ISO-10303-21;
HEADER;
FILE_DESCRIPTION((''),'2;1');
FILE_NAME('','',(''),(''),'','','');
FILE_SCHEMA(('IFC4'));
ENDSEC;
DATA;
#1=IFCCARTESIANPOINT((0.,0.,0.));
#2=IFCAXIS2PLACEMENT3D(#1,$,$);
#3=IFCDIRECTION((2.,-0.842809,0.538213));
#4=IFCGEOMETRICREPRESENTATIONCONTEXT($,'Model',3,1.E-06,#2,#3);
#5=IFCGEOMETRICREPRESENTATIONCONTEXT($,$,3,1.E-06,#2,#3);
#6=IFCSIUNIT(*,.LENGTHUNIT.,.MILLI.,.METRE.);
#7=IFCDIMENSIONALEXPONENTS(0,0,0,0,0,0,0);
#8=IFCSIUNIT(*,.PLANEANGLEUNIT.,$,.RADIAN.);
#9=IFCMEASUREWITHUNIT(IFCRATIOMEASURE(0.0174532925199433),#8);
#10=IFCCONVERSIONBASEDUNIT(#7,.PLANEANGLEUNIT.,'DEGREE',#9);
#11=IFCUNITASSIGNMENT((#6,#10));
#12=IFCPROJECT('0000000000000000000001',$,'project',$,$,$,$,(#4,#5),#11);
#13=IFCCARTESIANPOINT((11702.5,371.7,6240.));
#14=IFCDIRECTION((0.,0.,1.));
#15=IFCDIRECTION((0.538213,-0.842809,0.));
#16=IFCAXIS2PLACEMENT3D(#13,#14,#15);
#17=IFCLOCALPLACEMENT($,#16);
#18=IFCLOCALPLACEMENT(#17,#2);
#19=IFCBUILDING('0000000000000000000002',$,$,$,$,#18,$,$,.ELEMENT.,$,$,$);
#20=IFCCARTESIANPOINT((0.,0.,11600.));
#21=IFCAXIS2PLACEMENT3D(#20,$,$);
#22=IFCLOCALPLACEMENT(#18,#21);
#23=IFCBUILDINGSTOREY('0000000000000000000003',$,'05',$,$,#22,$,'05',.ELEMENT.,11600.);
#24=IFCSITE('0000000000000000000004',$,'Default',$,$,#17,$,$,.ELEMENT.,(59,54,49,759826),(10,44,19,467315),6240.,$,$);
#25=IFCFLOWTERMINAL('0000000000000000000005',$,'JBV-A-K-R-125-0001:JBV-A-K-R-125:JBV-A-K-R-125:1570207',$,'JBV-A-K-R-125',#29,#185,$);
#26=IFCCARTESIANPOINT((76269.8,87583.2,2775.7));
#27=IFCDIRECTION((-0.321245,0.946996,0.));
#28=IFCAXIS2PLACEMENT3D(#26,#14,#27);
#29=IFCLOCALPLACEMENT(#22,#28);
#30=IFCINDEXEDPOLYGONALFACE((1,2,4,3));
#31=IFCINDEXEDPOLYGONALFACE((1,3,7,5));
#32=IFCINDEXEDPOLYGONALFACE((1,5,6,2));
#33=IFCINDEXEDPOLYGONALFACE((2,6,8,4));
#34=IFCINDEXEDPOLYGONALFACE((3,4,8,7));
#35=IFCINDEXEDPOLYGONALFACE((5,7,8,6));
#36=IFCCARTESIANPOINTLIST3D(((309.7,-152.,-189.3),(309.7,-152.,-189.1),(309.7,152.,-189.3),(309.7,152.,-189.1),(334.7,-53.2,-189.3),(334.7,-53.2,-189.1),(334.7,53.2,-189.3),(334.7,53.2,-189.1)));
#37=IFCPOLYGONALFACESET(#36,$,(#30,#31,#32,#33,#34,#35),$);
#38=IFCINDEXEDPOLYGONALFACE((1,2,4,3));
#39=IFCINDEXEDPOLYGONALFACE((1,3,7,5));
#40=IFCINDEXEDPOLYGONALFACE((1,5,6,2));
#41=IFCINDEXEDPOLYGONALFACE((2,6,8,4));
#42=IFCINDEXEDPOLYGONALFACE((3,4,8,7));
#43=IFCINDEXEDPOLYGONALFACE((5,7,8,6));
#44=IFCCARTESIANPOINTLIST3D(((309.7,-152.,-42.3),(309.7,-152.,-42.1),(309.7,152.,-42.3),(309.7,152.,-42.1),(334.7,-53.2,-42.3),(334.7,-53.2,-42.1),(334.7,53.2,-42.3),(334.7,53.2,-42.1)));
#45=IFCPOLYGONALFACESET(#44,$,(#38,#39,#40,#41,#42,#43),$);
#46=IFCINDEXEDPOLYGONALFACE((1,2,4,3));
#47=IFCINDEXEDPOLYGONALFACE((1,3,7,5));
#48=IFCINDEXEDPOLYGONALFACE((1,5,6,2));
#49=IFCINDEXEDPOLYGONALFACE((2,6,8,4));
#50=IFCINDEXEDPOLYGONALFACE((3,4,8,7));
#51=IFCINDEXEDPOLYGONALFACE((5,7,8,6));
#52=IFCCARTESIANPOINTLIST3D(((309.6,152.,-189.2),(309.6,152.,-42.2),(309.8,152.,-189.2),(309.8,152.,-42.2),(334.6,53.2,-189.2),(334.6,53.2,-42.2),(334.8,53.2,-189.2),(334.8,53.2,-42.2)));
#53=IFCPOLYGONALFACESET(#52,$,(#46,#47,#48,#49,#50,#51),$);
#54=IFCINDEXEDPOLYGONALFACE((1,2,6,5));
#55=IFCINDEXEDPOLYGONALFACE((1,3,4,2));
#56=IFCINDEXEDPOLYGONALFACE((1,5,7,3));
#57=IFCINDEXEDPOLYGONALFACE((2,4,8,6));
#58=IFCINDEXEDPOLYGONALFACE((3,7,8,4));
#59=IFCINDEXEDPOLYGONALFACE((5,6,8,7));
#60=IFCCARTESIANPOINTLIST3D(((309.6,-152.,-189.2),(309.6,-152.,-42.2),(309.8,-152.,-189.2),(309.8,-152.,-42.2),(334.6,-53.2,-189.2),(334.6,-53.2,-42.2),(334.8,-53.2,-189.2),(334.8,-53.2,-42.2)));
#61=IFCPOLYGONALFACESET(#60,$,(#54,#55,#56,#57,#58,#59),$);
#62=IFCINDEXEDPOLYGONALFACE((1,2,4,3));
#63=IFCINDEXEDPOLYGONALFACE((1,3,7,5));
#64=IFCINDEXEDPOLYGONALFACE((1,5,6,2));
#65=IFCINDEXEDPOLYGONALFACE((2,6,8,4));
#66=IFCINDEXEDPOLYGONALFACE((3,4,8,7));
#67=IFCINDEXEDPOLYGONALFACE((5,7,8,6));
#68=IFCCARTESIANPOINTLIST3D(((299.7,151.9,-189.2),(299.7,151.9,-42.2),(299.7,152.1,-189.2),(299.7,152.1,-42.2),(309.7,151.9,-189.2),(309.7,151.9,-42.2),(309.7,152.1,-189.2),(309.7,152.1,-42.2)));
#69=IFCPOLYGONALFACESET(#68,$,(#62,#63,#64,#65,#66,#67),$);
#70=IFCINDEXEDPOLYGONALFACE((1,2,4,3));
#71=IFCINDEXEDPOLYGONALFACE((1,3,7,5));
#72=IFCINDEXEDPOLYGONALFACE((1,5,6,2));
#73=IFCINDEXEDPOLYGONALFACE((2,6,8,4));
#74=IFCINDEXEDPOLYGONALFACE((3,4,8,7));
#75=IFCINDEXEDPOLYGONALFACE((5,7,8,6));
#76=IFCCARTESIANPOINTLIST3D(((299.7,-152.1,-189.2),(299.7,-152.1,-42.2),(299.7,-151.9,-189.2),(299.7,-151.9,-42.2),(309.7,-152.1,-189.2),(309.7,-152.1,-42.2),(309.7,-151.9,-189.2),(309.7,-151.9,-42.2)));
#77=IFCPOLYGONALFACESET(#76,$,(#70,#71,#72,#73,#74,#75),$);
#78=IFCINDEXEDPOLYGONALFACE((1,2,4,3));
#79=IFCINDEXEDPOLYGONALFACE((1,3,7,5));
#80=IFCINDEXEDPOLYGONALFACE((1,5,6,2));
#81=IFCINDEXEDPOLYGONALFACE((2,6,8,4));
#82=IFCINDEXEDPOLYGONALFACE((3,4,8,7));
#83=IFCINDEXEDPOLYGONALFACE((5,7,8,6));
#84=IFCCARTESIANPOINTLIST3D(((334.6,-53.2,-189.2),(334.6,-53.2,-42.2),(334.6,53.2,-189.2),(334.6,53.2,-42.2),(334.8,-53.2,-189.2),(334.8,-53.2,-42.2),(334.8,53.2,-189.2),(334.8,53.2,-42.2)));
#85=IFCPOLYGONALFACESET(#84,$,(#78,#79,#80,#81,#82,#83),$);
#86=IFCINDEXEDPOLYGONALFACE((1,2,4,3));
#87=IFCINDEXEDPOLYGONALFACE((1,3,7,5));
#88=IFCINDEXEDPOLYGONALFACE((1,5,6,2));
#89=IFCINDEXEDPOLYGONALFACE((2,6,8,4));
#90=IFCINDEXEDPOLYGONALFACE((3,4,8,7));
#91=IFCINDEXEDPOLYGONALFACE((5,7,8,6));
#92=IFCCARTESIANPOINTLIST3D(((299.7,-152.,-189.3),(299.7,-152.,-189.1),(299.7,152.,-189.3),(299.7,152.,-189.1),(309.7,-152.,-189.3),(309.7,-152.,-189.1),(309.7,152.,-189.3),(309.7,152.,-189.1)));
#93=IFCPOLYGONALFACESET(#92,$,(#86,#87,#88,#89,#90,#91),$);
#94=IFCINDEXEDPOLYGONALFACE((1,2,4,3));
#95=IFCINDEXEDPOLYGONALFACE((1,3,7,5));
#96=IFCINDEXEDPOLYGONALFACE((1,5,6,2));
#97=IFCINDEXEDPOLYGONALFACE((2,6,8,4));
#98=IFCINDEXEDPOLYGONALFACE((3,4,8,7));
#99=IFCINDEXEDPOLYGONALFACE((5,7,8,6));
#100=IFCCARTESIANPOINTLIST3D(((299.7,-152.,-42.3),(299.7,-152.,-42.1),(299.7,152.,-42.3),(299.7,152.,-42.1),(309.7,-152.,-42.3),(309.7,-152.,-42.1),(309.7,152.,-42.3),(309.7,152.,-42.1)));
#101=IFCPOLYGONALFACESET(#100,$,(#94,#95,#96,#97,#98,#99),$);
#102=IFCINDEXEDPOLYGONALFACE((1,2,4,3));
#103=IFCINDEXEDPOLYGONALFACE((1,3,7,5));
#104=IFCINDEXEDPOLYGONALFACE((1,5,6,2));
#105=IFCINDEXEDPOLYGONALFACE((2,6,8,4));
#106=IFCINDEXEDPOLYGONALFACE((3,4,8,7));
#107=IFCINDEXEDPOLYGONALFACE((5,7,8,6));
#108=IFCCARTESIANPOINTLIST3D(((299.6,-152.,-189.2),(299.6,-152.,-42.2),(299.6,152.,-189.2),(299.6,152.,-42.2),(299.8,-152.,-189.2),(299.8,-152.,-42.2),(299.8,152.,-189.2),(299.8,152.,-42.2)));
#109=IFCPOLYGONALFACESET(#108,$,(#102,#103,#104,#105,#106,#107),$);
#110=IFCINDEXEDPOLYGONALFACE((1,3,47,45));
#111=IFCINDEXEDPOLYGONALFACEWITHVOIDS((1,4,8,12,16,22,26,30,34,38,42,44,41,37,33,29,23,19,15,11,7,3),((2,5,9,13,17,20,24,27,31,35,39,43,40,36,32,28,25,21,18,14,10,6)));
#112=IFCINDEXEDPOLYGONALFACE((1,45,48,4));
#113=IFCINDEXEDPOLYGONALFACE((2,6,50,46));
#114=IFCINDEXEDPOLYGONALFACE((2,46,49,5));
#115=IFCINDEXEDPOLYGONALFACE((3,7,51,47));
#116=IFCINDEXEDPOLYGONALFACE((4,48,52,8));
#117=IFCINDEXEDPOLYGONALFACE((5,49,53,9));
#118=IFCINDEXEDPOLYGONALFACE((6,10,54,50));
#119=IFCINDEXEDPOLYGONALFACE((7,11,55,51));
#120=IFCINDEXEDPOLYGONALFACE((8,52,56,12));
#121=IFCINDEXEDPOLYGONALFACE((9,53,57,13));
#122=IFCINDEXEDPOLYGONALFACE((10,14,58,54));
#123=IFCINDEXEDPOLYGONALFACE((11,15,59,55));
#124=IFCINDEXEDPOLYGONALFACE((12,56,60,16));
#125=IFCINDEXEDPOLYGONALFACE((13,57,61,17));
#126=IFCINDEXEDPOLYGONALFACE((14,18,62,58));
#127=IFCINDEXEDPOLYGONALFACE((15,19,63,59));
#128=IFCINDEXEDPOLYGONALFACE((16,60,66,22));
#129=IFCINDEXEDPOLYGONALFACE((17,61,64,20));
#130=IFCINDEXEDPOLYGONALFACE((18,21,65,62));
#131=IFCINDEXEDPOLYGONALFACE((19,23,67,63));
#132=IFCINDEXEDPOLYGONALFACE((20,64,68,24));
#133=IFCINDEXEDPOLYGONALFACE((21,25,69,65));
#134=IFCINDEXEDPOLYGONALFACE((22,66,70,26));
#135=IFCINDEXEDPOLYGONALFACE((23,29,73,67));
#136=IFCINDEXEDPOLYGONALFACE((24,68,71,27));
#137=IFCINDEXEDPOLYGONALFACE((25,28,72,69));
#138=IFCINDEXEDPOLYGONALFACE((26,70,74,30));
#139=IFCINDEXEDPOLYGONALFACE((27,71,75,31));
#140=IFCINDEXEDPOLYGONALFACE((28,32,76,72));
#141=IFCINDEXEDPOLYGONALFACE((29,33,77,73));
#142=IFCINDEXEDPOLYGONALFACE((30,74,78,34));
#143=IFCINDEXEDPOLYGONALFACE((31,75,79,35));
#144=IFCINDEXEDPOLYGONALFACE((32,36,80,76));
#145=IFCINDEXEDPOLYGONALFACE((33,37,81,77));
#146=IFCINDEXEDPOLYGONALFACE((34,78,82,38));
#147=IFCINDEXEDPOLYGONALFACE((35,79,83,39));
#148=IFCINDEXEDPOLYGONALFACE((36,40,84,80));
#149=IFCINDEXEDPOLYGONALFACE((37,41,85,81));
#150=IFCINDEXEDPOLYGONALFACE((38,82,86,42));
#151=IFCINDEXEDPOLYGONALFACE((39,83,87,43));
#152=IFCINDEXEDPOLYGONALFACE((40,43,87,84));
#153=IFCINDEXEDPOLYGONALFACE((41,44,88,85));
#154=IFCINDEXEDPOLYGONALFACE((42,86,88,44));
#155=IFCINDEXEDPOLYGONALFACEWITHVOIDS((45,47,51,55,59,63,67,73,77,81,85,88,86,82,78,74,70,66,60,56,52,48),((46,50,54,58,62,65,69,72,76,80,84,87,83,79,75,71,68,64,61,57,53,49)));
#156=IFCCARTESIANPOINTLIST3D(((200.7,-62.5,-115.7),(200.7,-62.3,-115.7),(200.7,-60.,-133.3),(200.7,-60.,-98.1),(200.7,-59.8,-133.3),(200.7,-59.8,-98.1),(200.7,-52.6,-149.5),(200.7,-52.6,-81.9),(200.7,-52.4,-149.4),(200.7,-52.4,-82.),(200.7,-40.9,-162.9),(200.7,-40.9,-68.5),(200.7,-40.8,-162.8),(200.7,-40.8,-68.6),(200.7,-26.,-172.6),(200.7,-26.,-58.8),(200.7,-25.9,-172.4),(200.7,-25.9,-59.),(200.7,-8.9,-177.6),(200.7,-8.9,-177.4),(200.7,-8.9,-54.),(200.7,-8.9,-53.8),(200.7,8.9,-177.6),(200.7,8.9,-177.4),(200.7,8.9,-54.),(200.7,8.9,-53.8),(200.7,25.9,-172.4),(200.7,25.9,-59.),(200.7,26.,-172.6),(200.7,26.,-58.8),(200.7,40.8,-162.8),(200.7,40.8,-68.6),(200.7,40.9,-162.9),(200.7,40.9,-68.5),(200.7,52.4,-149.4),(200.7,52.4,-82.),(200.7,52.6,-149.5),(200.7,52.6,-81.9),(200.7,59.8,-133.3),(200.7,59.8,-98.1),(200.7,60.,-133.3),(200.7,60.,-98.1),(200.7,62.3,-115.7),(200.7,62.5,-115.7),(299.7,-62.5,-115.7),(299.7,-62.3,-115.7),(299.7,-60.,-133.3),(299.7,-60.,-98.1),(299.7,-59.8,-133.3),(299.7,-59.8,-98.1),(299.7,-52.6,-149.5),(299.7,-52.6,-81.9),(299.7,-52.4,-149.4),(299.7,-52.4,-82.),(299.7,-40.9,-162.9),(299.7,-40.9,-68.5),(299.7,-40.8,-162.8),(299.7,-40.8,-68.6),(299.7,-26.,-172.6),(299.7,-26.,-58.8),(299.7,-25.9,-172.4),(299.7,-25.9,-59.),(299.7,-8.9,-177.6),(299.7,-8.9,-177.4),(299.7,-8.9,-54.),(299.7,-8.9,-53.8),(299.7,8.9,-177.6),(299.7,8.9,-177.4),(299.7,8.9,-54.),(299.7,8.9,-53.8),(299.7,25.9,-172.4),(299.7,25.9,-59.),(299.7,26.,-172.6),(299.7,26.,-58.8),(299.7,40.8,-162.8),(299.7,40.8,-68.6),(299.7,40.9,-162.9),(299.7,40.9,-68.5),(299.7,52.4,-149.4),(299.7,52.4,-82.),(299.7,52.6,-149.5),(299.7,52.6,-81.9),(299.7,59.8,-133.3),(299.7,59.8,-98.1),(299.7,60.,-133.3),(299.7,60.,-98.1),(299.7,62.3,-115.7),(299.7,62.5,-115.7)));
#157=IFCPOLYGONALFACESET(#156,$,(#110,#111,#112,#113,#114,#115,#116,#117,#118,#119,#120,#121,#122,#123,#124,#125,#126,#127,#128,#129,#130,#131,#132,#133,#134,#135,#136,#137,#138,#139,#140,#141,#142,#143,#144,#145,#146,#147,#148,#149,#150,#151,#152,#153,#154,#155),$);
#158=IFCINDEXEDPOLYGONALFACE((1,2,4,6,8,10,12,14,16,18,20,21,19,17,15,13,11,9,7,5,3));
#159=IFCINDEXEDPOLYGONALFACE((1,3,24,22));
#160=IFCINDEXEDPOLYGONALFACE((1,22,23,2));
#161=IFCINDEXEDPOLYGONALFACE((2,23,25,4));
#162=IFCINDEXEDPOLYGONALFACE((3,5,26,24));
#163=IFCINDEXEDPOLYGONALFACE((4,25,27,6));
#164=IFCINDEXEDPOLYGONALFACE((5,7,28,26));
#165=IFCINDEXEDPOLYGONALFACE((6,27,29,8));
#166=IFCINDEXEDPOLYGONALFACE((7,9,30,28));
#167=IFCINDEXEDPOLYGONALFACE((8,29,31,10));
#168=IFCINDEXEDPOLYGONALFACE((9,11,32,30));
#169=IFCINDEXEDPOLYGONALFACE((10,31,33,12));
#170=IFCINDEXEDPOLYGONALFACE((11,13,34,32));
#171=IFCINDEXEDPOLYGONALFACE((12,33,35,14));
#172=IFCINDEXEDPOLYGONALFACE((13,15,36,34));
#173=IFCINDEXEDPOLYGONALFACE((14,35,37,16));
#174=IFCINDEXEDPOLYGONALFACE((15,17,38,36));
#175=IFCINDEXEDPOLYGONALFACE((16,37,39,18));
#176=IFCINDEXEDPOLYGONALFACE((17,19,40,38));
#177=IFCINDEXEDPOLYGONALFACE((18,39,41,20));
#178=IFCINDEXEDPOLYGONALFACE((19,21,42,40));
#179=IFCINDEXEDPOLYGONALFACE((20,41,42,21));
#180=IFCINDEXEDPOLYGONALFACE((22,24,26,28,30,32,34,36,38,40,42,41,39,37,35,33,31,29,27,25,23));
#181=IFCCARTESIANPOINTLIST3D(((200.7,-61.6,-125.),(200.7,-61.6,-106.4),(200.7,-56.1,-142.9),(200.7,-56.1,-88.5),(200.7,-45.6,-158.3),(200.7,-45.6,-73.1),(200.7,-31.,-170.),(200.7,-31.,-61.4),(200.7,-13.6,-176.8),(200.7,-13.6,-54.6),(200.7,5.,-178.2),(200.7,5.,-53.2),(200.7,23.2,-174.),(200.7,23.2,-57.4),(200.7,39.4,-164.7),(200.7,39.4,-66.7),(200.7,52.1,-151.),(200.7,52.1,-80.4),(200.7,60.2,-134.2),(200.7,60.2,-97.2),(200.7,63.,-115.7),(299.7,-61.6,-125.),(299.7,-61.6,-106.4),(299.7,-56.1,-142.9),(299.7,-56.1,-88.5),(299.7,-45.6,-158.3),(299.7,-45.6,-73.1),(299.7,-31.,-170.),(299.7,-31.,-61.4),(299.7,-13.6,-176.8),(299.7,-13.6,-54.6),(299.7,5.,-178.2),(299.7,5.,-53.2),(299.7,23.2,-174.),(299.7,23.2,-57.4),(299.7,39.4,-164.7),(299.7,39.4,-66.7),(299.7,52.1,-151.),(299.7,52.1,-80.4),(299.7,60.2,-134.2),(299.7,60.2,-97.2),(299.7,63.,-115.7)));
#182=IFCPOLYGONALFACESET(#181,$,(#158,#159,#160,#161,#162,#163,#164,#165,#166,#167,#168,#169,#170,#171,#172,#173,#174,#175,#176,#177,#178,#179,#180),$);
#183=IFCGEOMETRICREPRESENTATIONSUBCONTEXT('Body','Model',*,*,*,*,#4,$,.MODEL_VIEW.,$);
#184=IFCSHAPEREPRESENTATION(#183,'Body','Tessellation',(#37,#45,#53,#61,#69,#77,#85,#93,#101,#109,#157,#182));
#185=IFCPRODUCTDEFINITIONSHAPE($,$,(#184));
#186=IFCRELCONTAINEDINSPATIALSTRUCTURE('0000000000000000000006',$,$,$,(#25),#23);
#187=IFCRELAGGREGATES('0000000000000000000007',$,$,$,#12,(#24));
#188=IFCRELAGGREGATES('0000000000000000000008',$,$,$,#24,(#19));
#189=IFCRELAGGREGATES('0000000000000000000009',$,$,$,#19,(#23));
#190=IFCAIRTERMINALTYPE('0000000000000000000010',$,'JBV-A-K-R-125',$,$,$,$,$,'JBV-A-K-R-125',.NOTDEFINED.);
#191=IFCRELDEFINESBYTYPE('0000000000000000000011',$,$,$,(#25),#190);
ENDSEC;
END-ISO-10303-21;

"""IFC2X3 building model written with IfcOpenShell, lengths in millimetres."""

from ifc_helpers import new_model, entity, si_unit, converted_unit, direction, frame, frame_2d, origin, origin_2d_with_axis, place, context, subcontext, project, spatial, polyline, circle_curve, parameter, trimmed, segment, composite_curve, rectangle, circle, outline, extrude, source, transform, mapped, type_object, type_shapes, element, save


model = new_model("IFC2X3")

# Units and contexts
model_context = context("Model", 3, precision=1e-06, world=origin(), true_north=direction((2.0, -0.842809, 0.538213)))
context_of_model = context(None, 3, precision=1e-06, world=origin(), true_north=direction((2.0, -0.842809, 0.538213)))
body_context = subcontext(model_context, "Body", "Model", "MODEL_VIEW")
ifc_project = project(units=[si_unit("LENGTHUNIT", "METRE", prefix="MILLI"), converted_unit("PLANEANGLEUNIT", "DEGREE", entity("IfcRatioMeasure", 0.0174532925199433), si_unit("PLANEANGLEUNIT", "RADIAN"), dimensions=[0, 0, 0, 0, 0, 0, 0])], contexts=[model_context, context_of_model])

# Site, building, storey
site_placement = place(None, frame((11702.5, 371.7, 6240.0), z_axis=(0.0, 0.0, 1.0), x_axis=(0.538213, -0.842809, 0.0)))
site = spatial("IfcSite", under=ifc_project, at=site_placement, Name="Default", CompositionType="ELEMENT", RefLatitude=(59, 54, 49, 759826), RefLongitude=(10, 44, 19, 467315), RefElevation=6240.0)
building_placement = place(site_placement, origin())
building = spatial("IfcBuilding", under=site, at=building_placement, CompositionType="ELEMENT")
storey_placement = place(building_placement, frame((0.0, 0.0, 11600.0)))
storey = spatial("IfcBuildingStorey", under=building, at=storey_placement, Name="05", LongName="05", CompositionType="ELEMENT", Elevation=11600.0)

# Flow terminal
air_terminal_type_1 = type_object("IfcAirTerminalType", Name="JBV-A-K-R-125", ElementType="JBV-A-K-R-125", PredefinedType="NOTDEFINED")
shared_shape_1 = source(origin(), body_context, "Body", "SweptSolid", [
    extrude(outline(polyline([(-152.0, -12.5), (152.0, -12.5), (53.2, 12.5), (-53.2, 12.5), (-152.0, -12.5)])), frame((322.2, 0.0, -189.3), z_axis=(0.0, 0.0, 1.0), x_axis=(0.0, -1.0, 0.0)), (0.0, 0.0, 1.0), 0.2),
    extrude(outline(polyline([(-152.0, -12.5), (152.0, -12.5), (53.2, 12.5), (-53.2, 12.5), (-152.0, -12.5)])), frame((322.2, 0.0, -42.3), z_axis=(0.0, 0.0, 1.0), x_axis=(0.0, -1.0, 0.0)), (0.0, 0.0, 1.0), 0.2),
    extrude(rectangle(XDim=0.2, YDim=101.9, at=frame_2d((0.0, 0.0), x_axis=(1.0, 0.0))), frame((322.2, 102.6, -189.2), z_axis=(0.0, 0.0, 1.0), x_axis=(0.969446, 0.245305, 0.0)), (0.0, 0.0, 1.0), 147.0),
    extrude(rectangle(XDim=0.2, YDim=101.9, at=frame_2d((0.0, 0.0), x_axis=(1.0, 0.0))), frame((322.2, -102.6, -189.2), z_axis=(0.0, 0.0, 1.0), x_axis=(-0.969446, 0.245305, 0.0)), (0.0, 0.0, 1.0), 147.0),
    extrude(rectangle(XDim=0.2, YDim=10.0, at=frame_2d((0.0, 0.0), x_axis=(1.0, 0.0))), frame((304.7, 152.0, -189.2), z_axis=(0.0, 0.0, 1.0), x_axis=(0.0, 1.0, 0.0)), (0.0, 0.0, 1.0), 147.0),
    extrude(rectangle(XDim=0.2, YDim=10.0, at=frame_2d((0.0, 0.0), x_axis=(1.0, 0.0))), frame((304.7, -152.0, -189.2), z_axis=(0.0, 0.0, 1.0), x_axis=(0.0, 1.0, 0.0)), (0.0, 0.0, 1.0), 147.0),
    extrude(rectangle(XDim=0.2, YDim=106.4, at=frame_2d((0.0, 0.0), x_axis=(1.0, 0.0))), frame((334.7, 0.0, -189.2)), (0.0, 0.0, 1.0), 147.0),
    extrude(rectangle(XDim=304.0, YDim=10.0, at=frame_2d((0.0, 0.0), x_axis=(1.0, 0.0))), frame((304.7, 0.0, -189.3), z_axis=(0.0, 0.0, 1.0), x_axis=(0.0, -1.0, 0.0)), (0.0, 0.0, 1.0), 0.2),
    extrude(rectangle(XDim=304.0, YDim=10.0, at=frame_2d((0.0, 0.0), x_axis=(1.0, 0.0))), frame((304.7, 0.0, -42.3), z_axis=(0.0, 0.0, 1.0), x_axis=(0.0, -1.0, 0.0)), (0.0, 0.0, 1.0), 0.2),
    extrude(rectangle(XDim=0.2, YDim=304.0, at=frame_2d((0.0, 0.0), x_axis=(1.0, 0.0))), frame((299.7, 0.0, -189.2)), (0.0, 0.0, 1.0), 147.0),
    extrude(outline(composite_curve([segment(trimmed(circle_curve(origin_2d_with_axis(), 62.5), [parameter(0.0)], [parameter(180.0)], True, "PARAMETER"), True, "CONTINUOUS"), segment(trimmed(circle_curve(origin_2d_with_axis(), 62.5), [parameter(180.0)], [parameter(360.0)], True, "PARAMETER"), True, "CONTINUOUS")], self_intersect=False), holes=[composite_curve([segment(trimmed(circle_curve(origin_2d_with_axis(), 62.3), [parameter(180.0)], [parameter(360.0)], True, "PARAMETER"), False, "CONTINUOUS"), segment(trimmed(circle_curve(origin_2d_with_axis(), 62.3), [parameter(0.0)], [parameter(180.0)], True, "PARAMETER"), False, "CONTINUOUS")], self_intersect=False)]), frame((200.7, 0.0, -115.7), z_axis=(1.0, 0.0, 0.0), x_axis=(0.0, 1.0, 0.0)), (0.0, 0.0, 1.0), 99.0),
    extrude(circle(Radius=62.6, at=frame_2d((0.0, 0.0), x_axis=(1.0, 0.0))), frame((200.7, 0.3, -115.7), z_axis=(1.0, 0.0, 0.0), x_axis=(0.0, 1.0, 0.0)), (0.0, 0.0, 1.0), 99.0),
])
type_shapes(air_terminal_type_1, [shared_shape_1])
flow_terminal_1_placement = place(storey_placement, frame((76269.8, 87583.2, 2775.7), z_axis=(0.0, 0.0, 1.0), x_axis=(-0.321245, 0.946996, 0.0)))
element("IfcFlowTerminal", 1, at=flow_terminal_1_placement, inside=storey, type_object=air_terminal_type_1, Name="JBV-A-K-R-125-0001:JBV-A-K-R-125:JBV-A-K-R-125:1570207", ObjectType="JBV-A-K-R-125", context=body_context, shape_type="MappedRepresentation", body=[
    mapped(shared_shape_1, transform((0.0, 0.0, 0.0), scale=1.0)),
])

save(model, "model.ifc")
